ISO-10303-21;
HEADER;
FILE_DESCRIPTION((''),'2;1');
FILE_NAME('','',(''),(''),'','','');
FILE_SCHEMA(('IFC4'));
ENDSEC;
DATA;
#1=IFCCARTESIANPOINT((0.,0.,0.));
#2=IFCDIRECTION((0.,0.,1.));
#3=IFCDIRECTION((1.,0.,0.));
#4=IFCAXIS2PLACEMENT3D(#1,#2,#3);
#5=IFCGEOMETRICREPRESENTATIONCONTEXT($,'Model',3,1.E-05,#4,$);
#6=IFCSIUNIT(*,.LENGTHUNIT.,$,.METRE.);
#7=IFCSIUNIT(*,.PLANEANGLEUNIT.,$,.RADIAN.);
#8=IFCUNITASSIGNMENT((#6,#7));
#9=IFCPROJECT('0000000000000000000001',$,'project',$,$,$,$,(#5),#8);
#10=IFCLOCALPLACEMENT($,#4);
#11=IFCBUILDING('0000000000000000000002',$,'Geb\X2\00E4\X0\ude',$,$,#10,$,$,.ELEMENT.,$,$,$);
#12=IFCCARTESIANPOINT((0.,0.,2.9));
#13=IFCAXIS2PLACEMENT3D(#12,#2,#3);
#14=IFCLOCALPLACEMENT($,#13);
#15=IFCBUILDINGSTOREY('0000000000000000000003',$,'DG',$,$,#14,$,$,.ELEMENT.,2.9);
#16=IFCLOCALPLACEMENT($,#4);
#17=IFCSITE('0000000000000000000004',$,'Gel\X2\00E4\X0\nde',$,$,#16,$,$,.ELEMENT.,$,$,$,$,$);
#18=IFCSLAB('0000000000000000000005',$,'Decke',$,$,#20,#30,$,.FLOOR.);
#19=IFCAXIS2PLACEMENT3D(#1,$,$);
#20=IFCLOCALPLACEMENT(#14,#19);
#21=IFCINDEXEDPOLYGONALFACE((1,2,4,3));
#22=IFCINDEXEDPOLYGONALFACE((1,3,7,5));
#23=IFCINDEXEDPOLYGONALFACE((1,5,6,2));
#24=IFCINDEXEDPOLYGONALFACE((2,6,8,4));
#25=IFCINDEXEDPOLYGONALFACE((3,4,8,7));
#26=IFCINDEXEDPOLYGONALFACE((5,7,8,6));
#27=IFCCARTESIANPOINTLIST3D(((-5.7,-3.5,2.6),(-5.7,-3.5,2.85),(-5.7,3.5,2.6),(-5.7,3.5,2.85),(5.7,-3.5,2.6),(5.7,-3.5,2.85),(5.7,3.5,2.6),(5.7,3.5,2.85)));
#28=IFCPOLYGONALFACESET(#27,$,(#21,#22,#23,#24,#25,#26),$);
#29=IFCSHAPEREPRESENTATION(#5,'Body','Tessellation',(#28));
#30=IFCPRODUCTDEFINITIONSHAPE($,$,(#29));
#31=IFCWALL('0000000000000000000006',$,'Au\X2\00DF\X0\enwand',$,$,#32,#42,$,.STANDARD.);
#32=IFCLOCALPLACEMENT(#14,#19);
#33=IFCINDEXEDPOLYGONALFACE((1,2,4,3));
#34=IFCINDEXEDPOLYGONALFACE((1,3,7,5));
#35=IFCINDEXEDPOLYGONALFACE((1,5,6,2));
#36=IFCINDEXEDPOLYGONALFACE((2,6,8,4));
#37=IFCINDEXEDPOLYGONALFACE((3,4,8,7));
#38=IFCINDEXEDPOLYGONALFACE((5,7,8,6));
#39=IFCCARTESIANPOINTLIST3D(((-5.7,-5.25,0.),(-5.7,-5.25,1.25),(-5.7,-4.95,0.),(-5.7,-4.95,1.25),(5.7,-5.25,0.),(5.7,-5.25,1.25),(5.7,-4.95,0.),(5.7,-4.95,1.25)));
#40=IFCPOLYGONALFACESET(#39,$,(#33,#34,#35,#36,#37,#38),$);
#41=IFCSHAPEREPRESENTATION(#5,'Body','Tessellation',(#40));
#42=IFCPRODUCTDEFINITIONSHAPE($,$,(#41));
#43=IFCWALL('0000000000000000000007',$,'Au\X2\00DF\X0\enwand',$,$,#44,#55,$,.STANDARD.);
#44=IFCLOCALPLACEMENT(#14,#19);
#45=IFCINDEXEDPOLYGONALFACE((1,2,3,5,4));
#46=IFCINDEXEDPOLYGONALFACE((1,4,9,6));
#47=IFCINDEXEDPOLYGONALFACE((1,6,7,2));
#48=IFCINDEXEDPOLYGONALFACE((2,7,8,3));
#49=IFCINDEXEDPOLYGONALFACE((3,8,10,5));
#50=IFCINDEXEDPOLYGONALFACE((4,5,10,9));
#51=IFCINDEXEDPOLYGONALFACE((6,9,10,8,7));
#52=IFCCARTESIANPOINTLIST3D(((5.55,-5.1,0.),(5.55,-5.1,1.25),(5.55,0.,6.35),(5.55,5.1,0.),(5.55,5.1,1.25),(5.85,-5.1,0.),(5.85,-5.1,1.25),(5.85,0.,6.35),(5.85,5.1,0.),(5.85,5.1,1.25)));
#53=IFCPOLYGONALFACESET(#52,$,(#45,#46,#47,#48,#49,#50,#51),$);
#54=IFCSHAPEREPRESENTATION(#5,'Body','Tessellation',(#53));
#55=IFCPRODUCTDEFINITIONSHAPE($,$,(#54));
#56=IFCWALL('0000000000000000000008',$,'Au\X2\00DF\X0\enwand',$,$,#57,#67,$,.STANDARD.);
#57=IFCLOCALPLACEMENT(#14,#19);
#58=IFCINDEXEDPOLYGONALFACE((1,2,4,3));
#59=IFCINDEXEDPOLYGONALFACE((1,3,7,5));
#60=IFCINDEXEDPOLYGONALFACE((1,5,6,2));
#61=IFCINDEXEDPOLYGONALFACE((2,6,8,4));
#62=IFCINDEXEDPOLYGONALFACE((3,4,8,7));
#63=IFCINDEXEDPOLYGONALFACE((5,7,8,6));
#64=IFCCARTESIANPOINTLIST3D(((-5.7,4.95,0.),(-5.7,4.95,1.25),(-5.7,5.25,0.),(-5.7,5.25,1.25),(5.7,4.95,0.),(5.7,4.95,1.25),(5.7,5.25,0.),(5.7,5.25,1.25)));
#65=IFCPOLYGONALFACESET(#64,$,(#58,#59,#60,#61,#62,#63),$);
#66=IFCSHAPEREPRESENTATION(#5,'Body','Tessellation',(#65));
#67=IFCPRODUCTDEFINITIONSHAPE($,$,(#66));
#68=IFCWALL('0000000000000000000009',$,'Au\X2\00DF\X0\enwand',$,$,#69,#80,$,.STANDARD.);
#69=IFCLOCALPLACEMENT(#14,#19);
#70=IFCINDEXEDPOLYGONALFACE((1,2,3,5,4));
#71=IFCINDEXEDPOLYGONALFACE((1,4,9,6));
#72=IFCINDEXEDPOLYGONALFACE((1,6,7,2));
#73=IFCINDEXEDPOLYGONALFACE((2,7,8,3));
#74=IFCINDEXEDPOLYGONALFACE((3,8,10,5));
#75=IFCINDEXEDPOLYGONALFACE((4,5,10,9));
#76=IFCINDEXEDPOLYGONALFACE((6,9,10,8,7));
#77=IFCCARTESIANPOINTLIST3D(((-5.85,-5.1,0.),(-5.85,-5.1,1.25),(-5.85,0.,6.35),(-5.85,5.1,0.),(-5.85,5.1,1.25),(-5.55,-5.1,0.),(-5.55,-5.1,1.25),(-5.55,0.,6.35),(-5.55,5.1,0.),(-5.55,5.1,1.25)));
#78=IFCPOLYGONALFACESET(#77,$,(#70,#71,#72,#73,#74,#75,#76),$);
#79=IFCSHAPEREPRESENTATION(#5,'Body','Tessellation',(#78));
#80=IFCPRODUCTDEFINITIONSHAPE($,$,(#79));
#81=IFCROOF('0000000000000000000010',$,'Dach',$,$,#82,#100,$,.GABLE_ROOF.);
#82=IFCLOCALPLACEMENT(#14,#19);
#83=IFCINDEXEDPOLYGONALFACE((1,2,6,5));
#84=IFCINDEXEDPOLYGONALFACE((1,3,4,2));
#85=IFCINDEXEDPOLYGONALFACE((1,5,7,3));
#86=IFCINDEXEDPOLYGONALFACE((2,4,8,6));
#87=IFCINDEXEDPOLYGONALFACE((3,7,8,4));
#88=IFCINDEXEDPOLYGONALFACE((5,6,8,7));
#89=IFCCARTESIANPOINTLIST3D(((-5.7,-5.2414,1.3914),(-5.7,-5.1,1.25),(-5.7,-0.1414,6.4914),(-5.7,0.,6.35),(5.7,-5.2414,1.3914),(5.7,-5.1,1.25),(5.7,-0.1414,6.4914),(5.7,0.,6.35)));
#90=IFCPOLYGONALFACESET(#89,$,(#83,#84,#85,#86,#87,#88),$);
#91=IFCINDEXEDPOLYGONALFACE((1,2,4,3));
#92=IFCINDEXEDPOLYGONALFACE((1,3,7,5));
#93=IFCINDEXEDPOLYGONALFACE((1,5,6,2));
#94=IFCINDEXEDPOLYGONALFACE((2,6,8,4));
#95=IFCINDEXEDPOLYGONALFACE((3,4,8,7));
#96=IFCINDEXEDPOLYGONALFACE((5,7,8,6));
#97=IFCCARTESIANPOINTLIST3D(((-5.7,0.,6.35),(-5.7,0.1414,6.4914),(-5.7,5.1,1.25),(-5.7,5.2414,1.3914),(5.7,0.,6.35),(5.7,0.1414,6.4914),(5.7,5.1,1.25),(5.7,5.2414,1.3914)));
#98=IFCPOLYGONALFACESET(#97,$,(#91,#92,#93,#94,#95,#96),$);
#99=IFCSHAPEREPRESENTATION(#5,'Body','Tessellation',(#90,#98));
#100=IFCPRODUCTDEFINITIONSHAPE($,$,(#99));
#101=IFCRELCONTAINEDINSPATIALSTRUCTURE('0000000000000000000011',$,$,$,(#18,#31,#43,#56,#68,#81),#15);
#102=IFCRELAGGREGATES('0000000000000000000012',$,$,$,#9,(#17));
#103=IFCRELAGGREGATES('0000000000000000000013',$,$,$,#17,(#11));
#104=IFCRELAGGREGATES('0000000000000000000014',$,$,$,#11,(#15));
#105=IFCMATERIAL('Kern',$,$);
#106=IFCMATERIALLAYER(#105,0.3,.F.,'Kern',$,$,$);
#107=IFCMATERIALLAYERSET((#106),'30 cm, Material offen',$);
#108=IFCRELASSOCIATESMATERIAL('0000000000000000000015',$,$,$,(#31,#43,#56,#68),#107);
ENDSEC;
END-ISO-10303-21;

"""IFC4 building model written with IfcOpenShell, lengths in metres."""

from ifc_helpers import new_model, si_unit, frame, origin_with_axes, origin_2d, place, context, project, spatial, polyline, rectangle, outline, extrude, material, layer, layer_set, element, save


model = new_model("IFC4")

# Units and contexts
model_context = context("Model", 3, precision=1e-05, world=origin_with_axes())
ifc_project = project(units=[si_unit("LENGTHUNIT", "METRE"), si_unit("PLANEANGLEUNIT", "RADIAN")], contexts=[model_context])

# Site, building, storey
site_placement = place(None, origin_with_axes())
site = spatial("IfcSite", under=ifc_project, at=site_placement, Name="Gelände", CompositionType="ELEMENT")
building_placement = place(None, origin_with_axes())
building = spatial("IfcBuilding", under=site, at=building_placement, Name="Gebäude", CompositionType="ELEMENT")
storey_placement = place(None, frame((0.0, 0.0, 2.9), z_axis=(0.0, 0.0, 1.0), x_axis=(1.0, 0.0, 0.0)))
storey = spatial("IfcBuildingStorey", under=building, at=storey_placement, Name="DG", CompositionType="ELEMENT", Elevation=2.9)

# Slab
slab_placement = place(None, frame((0.0, 0.0, 5.5), z_axis=(0.0, 0.0, 1.0), x_axis=(1.0, 0.0, 0.0)))
element("IfcSlab", 1, at=slab_placement, inside=storey, Name="Decke", PredefinedType="FLOOR", context=model_context, shape_type="SweptSolid", body=[
    extrude(outline(polyline([(5.7, -3.5), (5.7, 3.5), (-5.7, 3.5), (-5.7, -3.5), (5.7, -3.5)])), origin_with_axes(), (0.0, 0.0, 1.0), 0.25),
])

# Walls
ifc_material = material(Name="Kern")
ifc_layer = layer(ifc_material, 0.3, ventilated=False, Name="Kern")
ifc_layer_set = layer_set([ifc_layer], Name="30 cm, Material offen")
wall_1_placement = place(None, frame((0.0, -5.1, 2.9), z_axis=(0.0, 0.0, 1.0), x_axis=(1.0, 0.0, 0.0)))
element("IfcWall", 2, at=wall_1_placement, inside=storey, material=ifc_layer_set, Name="Außenwand", PredefinedType="STANDARD", context=model_context, shape_type="SweptSolid", body=[
    extrude(rectangle(XDim=11.4, YDim=0.3, at=origin_2d()), origin_with_axes(), (0.0, 0.0, 1.0), 1.25),
])
wall_2_placement = place(None, frame((5.7, 0.0, 2.9), z_axis=(0.0, 0.0, 1.0), x_axis=(0.0, 1.0, 0.0)))
element("IfcWall", 3, at=wall_2_placement, inside=storey, material=ifc_layer_set, Name="Außenwand", PredefinedType="STANDARD", context=model_context, shape_type="SweptSolid", body=[
    extrude(outline(polyline([(-5.1, 0.0), (5.1, 0.0), (5.1, 1.25), (0.0, 6.35), (-5.1, 1.25), (-5.1, 0.0)])), frame((0.0, 0.15, 0.0), z_axis=(0.0, -1.0, 0.0), x_axis=(1.0, 0.0, 0.0)), (0.0, 0.0, 1.0), 0.3),
])
wall_3_placement = place(None, frame((0.0, 5.1, 2.9), z_axis=(0.0, 0.0, 1.0), x_axis=(-1.0, 0.0, 0.0)))
element("IfcWall", 4, at=wall_3_placement, inside=storey, material=ifc_layer_set, Name="Außenwand", PredefinedType="STANDARD", context=model_context, shape_type="SweptSolid", body=[
    extrude(rectangle(XDim=11.4, YDim=0.3, at=origin_2d()), origin_with_axes(), (0.0, 0.0, 1.0), 1.25),
])
wall_4_placement = place(None, frame((-5.7, 0.0, 2.9), z_axis=(0.0, 0.0, 1.0), x_axis=(0.0, -1.0, 0.0)))
element("IfcWall", 5, at=wall_4_placement, inside=storey, material=ifc_layer_set, Name="Außenwand", PredefinedType="STANDARD", context=model_context, shape_type="SweptSolid", body=[
    extrude(outline(polyline([(-5.1, 0.0), (5.1, 0.0), (5.1, 1.25), (0.0, 6.35), (-5.1, 1.25), (-5.1, 0.0)])), frame((0.0, 0.15, 0.0), z_axis=(0.0, -1.0, 0.0), x_axis=(1.0, 0.0, 0.0)), (0.0, 0.0, 1.0), 0.3),
])

# Roof
roof_placement = place(None, frame((0.0, 0.0, 4.15), z_axis=(0.0, 0.0, 1.0), x_axis=(1.0, 0.0, 0.0)))
element("IfcRoof", 6, at=roof_placement, inside=storey, Name="Dach", PredefinedType="GABLE_ROOF", context=model_context, shape_type="SweptSolid", body=[
    extrude(outline(polyline([(0.0, 0.0), (7.2125, 0.0), (7.2125, -11.4), (0.0, -11.4), (0.0, 0.0)])), frame((-5.7, -5.1, 0.0), z_axis=(0.0, -0.7071, 0.7071), x_axis=(0.0, 0.7071, 0.7071)), (0.0, 0.0, 1.0), 0.2),
    extrude(outline(polyline([(0.0, 0.0), (7.2125, 0.0), (7.2125, -11.4), (0.0, -11.4), (0.0, 0.0)])), frame((-5.7, 0.0, 5.1), z_axis=(0.0, 0.7071, 0.7071), x_axis=(0.0, 0.7071, -0.7071)), (0.0, 0.0, 1.0), 0.2),
])

save(model, "model.ifc")
